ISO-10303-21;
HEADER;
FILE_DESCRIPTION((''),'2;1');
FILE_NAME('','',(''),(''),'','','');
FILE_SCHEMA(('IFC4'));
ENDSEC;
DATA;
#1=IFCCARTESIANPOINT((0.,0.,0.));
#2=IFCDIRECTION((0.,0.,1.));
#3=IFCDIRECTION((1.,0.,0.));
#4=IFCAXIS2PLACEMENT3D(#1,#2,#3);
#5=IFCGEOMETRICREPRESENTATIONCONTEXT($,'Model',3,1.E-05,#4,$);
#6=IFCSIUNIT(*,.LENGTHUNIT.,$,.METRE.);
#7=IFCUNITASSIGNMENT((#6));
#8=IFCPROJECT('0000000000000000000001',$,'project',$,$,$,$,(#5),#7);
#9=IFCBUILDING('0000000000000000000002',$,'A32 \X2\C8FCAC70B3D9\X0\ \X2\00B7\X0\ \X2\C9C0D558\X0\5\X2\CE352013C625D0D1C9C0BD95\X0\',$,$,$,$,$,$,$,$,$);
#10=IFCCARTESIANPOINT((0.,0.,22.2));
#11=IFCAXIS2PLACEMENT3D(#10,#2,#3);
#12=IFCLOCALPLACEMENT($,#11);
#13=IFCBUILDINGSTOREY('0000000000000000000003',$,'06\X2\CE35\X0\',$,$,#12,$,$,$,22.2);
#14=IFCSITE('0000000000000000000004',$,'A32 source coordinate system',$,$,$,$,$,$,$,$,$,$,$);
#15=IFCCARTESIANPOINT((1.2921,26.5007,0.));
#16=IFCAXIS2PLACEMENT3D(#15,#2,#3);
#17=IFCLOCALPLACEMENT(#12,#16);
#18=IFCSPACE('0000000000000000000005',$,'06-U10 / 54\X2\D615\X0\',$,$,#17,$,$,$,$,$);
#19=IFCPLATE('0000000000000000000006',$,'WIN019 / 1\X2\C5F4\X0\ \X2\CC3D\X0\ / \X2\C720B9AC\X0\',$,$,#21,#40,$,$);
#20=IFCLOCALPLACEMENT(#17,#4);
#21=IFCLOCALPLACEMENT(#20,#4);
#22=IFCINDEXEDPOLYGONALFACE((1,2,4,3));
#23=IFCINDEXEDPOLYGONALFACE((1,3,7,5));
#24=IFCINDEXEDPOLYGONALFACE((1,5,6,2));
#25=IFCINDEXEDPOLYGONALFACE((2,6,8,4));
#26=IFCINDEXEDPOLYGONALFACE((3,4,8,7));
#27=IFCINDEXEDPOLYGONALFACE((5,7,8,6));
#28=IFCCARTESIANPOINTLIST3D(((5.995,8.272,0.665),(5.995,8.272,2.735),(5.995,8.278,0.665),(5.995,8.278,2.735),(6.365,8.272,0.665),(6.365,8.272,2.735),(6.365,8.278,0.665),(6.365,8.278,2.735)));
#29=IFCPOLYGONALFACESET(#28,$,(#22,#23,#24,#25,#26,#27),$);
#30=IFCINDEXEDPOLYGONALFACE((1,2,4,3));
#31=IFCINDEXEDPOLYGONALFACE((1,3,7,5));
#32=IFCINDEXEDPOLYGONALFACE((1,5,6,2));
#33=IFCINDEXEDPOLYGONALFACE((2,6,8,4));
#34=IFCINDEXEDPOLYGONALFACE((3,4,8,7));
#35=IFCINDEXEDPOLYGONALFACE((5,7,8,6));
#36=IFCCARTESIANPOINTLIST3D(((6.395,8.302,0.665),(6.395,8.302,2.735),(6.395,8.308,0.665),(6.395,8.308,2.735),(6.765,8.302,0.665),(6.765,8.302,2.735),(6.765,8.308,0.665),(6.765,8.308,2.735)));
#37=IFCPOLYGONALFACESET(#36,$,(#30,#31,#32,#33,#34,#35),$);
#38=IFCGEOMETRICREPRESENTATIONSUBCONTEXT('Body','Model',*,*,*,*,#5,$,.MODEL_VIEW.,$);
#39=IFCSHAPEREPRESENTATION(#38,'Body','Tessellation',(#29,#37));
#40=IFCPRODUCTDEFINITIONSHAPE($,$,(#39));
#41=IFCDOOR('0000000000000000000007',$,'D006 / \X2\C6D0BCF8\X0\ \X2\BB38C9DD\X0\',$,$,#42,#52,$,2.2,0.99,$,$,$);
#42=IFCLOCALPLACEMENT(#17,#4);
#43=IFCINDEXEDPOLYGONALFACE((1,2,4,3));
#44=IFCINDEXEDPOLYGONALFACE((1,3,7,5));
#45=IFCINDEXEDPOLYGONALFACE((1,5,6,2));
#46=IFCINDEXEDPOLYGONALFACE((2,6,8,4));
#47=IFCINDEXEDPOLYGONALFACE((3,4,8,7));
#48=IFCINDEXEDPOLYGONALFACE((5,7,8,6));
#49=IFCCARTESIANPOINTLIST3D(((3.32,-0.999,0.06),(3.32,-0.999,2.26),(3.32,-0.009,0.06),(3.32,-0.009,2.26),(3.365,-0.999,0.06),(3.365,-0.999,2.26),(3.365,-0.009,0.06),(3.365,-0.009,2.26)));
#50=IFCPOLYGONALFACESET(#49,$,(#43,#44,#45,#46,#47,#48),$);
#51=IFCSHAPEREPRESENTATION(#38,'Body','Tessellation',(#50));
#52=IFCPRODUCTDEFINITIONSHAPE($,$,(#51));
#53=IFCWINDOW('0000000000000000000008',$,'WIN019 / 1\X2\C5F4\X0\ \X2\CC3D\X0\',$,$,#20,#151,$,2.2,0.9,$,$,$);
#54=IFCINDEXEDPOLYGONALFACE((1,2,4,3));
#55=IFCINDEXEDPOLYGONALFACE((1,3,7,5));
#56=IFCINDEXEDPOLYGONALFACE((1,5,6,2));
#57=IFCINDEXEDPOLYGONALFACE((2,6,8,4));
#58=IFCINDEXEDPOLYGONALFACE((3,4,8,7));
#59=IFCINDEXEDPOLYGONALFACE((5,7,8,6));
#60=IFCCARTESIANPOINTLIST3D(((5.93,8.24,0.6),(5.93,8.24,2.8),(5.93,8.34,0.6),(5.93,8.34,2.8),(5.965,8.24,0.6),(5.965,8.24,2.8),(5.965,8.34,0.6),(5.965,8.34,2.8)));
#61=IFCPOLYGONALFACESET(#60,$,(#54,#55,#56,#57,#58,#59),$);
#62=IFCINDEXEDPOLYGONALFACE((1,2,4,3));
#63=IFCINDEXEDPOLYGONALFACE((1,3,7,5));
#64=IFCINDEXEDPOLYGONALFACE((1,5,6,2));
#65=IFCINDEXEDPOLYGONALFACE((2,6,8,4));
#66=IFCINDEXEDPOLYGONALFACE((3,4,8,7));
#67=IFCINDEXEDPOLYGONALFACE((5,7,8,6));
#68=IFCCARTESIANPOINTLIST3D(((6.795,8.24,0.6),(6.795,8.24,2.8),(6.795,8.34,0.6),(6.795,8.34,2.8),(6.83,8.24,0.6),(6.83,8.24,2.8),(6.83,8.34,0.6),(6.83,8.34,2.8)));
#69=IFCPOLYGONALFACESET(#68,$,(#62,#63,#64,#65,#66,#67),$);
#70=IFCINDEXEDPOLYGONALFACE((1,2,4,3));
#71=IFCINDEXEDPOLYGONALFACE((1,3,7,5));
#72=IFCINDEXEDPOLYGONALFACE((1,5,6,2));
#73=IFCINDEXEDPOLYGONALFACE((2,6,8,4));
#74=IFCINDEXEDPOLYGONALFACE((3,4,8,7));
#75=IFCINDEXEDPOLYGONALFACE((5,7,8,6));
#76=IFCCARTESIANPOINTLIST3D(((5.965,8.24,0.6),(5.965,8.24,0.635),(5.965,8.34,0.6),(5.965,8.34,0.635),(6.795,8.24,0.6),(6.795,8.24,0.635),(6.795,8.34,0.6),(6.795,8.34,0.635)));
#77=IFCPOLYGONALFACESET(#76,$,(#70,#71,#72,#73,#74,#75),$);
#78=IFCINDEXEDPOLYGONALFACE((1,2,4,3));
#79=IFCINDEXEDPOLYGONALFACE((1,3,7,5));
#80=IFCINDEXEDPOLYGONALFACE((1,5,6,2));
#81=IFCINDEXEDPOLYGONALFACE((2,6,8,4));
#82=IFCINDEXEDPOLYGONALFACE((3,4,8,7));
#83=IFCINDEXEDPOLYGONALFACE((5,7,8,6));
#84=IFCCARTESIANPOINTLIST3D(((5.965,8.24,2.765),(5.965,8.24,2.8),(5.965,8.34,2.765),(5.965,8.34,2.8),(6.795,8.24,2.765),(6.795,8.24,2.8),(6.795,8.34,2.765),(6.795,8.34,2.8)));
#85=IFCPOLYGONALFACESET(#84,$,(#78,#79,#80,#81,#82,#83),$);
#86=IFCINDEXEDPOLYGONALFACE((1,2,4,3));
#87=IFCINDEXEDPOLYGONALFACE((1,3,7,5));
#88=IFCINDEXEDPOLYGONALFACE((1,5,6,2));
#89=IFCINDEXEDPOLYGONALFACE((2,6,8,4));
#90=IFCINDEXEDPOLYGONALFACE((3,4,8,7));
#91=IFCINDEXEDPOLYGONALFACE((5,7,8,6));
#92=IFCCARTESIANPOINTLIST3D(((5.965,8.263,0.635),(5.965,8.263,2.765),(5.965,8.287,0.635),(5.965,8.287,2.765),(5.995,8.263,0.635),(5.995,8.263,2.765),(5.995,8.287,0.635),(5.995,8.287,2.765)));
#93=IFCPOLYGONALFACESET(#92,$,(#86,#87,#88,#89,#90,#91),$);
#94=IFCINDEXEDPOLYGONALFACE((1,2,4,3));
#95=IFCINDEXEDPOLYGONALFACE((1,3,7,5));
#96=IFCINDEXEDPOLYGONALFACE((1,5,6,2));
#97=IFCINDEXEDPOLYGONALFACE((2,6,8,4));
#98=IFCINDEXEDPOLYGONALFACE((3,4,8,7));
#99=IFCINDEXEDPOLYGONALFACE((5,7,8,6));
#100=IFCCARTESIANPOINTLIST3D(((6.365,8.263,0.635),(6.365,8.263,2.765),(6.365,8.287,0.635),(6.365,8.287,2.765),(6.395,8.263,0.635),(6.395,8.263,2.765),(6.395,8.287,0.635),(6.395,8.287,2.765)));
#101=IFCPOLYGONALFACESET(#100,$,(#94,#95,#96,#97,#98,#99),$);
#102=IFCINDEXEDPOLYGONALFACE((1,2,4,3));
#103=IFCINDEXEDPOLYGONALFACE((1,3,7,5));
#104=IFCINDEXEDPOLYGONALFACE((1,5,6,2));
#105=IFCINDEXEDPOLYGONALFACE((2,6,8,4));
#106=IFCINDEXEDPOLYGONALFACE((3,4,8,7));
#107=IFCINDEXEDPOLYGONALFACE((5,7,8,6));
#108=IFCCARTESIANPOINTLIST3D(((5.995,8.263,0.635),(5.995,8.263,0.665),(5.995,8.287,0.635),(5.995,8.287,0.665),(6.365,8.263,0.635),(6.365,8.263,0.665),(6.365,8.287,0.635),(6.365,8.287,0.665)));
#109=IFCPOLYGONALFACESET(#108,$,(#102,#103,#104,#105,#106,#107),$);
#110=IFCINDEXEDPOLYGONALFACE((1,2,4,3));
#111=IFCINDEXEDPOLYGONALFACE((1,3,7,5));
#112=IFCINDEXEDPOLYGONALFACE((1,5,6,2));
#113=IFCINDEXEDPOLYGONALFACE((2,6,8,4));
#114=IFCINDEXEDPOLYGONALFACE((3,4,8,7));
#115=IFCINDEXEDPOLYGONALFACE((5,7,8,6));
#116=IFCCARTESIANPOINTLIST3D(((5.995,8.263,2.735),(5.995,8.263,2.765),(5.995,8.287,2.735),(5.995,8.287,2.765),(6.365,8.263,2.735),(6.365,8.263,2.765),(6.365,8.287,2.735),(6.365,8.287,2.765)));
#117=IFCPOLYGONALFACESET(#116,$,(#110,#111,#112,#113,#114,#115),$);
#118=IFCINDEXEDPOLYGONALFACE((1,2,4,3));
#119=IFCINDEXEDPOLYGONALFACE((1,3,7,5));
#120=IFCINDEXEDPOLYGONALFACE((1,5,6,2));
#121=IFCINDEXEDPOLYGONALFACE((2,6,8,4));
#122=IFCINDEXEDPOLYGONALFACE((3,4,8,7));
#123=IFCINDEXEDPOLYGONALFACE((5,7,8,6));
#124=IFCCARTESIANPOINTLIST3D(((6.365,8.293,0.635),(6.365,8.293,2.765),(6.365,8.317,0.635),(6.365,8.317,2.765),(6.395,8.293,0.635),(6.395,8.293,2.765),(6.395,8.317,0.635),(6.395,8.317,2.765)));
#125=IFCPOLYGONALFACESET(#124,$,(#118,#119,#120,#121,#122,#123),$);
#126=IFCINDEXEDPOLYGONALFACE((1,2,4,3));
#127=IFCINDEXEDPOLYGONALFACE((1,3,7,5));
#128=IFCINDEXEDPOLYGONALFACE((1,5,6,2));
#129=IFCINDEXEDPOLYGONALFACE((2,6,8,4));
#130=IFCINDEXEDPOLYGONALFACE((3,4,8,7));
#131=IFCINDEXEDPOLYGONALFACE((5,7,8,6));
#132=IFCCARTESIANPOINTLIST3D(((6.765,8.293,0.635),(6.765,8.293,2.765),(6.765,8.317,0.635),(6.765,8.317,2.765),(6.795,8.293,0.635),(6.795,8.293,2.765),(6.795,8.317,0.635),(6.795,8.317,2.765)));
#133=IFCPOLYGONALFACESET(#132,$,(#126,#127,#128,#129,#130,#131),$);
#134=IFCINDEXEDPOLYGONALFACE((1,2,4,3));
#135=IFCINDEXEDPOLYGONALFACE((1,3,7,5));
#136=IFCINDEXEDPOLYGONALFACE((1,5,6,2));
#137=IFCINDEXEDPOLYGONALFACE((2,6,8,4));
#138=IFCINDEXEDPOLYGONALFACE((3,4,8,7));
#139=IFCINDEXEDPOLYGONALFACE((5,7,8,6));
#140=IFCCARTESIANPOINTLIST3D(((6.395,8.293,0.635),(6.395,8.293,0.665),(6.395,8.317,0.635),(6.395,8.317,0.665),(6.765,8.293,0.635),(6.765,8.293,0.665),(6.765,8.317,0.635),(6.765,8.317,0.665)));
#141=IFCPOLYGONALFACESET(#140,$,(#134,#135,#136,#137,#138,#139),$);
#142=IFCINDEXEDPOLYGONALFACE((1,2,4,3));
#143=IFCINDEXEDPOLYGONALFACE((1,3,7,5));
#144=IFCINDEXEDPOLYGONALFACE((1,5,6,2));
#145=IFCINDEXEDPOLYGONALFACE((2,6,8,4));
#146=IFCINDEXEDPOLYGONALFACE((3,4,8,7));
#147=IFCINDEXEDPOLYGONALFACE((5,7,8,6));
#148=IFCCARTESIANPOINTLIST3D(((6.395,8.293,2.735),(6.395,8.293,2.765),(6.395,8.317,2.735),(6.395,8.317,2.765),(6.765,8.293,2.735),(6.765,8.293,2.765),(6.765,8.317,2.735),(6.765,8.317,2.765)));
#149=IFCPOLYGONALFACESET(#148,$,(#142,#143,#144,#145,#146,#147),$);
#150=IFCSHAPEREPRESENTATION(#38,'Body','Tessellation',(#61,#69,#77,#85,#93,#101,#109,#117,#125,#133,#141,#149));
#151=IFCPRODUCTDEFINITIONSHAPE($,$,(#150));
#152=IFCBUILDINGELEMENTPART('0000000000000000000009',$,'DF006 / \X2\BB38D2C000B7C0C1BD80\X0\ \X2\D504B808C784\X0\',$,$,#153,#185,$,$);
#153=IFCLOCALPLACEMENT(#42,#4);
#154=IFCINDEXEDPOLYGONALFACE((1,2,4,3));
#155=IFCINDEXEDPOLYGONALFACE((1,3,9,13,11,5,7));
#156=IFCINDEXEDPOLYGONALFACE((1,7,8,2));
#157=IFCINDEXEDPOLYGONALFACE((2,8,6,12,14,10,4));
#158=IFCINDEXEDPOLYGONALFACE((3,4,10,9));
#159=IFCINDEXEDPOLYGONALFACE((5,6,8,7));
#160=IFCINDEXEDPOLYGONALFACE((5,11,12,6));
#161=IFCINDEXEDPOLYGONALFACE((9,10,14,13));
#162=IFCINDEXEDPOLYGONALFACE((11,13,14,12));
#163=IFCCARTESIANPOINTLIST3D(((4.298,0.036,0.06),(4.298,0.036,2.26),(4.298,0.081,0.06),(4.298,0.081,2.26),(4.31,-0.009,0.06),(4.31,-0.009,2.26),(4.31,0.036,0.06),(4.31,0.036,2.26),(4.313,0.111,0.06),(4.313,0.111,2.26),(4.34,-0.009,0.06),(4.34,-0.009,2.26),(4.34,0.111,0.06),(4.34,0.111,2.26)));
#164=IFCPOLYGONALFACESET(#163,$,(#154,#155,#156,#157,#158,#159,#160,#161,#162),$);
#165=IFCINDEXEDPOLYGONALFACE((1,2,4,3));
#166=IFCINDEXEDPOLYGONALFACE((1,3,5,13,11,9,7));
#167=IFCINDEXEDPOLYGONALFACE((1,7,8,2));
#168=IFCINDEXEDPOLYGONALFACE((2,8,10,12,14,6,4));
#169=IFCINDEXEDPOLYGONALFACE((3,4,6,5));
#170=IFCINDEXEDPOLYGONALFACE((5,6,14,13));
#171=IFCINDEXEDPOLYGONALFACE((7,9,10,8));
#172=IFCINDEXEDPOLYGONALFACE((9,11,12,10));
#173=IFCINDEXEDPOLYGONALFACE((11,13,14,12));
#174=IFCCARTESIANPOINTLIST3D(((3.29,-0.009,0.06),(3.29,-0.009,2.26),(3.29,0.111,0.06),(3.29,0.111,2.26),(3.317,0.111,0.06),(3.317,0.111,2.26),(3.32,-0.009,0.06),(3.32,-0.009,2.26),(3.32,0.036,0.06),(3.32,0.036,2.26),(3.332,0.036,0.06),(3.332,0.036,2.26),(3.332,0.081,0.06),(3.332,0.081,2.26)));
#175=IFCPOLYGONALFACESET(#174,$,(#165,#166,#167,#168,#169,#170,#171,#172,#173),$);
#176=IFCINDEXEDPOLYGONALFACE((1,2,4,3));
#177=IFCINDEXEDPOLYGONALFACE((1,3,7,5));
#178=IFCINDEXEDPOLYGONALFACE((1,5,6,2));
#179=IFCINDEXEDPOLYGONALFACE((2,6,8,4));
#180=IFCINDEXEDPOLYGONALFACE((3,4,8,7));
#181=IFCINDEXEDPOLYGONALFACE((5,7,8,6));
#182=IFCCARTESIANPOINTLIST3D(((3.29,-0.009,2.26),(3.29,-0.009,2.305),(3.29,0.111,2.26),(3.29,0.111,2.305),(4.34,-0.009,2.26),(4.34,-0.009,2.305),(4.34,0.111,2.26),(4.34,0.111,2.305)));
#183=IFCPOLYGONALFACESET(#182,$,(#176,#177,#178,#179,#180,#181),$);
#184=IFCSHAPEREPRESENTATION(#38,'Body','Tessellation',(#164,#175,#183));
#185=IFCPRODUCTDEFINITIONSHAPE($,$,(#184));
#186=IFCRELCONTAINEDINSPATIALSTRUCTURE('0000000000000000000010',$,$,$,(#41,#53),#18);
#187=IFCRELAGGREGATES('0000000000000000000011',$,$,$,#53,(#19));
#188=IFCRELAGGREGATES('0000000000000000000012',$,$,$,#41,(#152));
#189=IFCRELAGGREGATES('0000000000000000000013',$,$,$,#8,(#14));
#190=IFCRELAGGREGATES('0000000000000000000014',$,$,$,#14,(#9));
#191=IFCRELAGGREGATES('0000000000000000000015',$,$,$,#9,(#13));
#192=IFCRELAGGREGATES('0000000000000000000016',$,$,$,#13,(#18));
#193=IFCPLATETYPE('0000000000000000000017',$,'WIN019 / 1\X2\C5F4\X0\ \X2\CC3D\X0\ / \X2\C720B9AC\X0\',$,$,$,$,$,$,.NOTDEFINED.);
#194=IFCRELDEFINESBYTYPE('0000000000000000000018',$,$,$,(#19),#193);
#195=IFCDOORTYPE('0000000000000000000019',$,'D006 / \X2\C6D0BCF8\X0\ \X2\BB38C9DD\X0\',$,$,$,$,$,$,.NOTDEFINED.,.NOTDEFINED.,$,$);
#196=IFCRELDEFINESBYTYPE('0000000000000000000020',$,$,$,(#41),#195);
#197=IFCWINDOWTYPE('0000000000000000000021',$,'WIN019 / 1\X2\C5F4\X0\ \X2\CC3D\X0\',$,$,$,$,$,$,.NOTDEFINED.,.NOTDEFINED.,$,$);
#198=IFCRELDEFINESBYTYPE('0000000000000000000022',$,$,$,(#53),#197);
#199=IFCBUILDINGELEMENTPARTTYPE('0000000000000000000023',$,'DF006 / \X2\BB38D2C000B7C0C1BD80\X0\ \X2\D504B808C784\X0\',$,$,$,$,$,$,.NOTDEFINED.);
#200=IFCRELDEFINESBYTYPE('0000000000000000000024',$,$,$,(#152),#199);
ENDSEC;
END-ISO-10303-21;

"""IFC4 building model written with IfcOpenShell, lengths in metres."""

from ifc_helpers import new_model, si_unit, frame, origin, origin_with_axes, place, context, subcontext, project, spatial, polyline, outline, extrude, source, transform, mapped, type_object, type_shapes, element, aggregate, save


model = new_model("IFC4")

# Units and contexts
model_context = context("Model", 3, precision=1e-05, world=origin_with_axes())
body_context = subcontext(model_context, "Body", "Model", "MODEL_VIEW")
ifc_project = project(units=[si_unit("LENGTHUNIT", "METRE")], contexts=[model_context])

# Plate
storey_placement = place(None, frame((0.0, 0.0, 22.2), z_axis=(0.0, 0.0, 1.0), x_axis=(1.0, 0.0, 0.0)))
space_placement = place(storey_placement, frame((1.2921, 26.5007, 0.0), z_axis=(0.0, 0.0, 1.0), x_axis=(1.0, 0.0, 0.0)))
plate_type_1 = type_object("IfcPlateType", Name="WIN019 / 1열 창 / 유리", PredefinedType="NOTDEFINED")
shared_shape_1 = source(origin(), body_context, "Body", "SweptSolid", [
    extrude(outline(polyline([(5.995, 8.272), (5.995, 8.278), (6.365, 8.278), (6.365, 8.272), (5.995, 8.272)])), frame((0.0, 0.0, 0.665)), (0.0, 0.0, 1.0), 2.07),
    extrude(outline(polyline([(6.395, 8.302), (6.395, 8.308), (6.765, 8.308), (6.765, 8.302), (6.395, 8.302)])), frame((0.0, 0.0, 0.665)), (0.0, 0.0, 1.0), 2.07),
])
type_shapes(plate_type_1, [shared_shape_1])
window_1_placement = place(space_placement, origin_with_axes())
plate_1_placement = place(window_1_placement, origin_with_axes())
plate_1 = element("IfcPlate", 1, at=plate_1_placement, type_object=plate_type_1, Name="WIN019 / 1열 창 / 유리", context=body_context, shape_type="MappedRepresentation", body=[
    mapped(shared_shape_1, transform((0.0, 0.0, 0.0), scale=1.0)),
])

# Site, building, storey, space
site = spatial("IfcSite", under=ifc_project, Name="A32 source coordinate system")
building = spatial("IfcBuilding", under=site, Name="A32 주거동 · 지하5층–옥탑지붕")
storey = spatial("IfcBuildingStorey", under=building, at=storey_placement, Name="06층", Elevation=22.2)
space = spatial("IfcSpace", under=storey, at=space_placement, Name="06-U10 / 54형")

# Door
door_type_1 = type_object("IfcDoorType", Name="D006 / 원본 문짝", OperationType="NOTDEFINED", PredefinedType="NOTDEFINED")
shared_shape_2 = source(origin(), body_context, "Body", "SweptSolid", [
    extrude(outline(polyline([(3.365, -0.999), (3.32, -0.999), (3.32, -0.009), (3.365, -0.009), (3.365, -0.999)])), frame((0.0, 0.0, 0.06)), (0.0, 0.0, 1.0), 2.2),
])
type_shapes(door_type_1, [shared_shape_2])
door_1_placement = place(space_placement, origin_with_axes())
door_1 = element("IfcDoor", 2, at=door_1_placement, inside=space, type_object=door_type_1, Name="D006 / 원본 문짝", OverallHeight=2.2, OverallWidth=0.99, context=body_context, shape_type="MappedRepresentation", body=[
    mapped(shared_shape_2, transform((0.0, 0.0, 0.0), scale=1.0)),
])

# Window
window_type_1 = type_object("IfcWindowType", Name="WIN019 / 1열 창", PartitioningType="NOTDEFINED", PredefinedType="NOTDEFINED")
shared_shape_3 = source(origin(), body_context, "Body", "SweptSolid", [
    extrude(outline(polyline([(5.93, 8.24), (5.93, 8.34), (5.965, 8.34), (5.965, 8.24), (5.93, 8.24)])), frame((0.0, 0.0, 0.6)), (0.0, 0.0, 1.0), 2.2),
    extrude(outline(polyline([(6.795, 8.24), (6.795, 8.34), (6.83, 8.34), (6.83, 8.24), (6.795, 8.24)])), frame((0.0, 0.0, 0.6)), (0.0, 0.0, 1.0), 2.2),
    extrude(outline(polyline([(5.965, 8.24), (5.965, 8.34), (6.795, 8.34), (6.795, 8.24), (5.965, 8.24)])), frame((0.0, 0.0, 0.6)), (0.0, 0.0, 1.0), 0.035),
    extrude(outline(polyline([(5.965, 8.24), (5.965, 8.34), (6.795, 8.34), (6.795, 8.24), (5.965, 8.24)])), frame((0.0, 0.0, 2.765)), (0.0, 0.0, 1.0), 0.035),
    extrude(outline(polyline([(5.965, 8.263), (5.965, 8.287), (5.995, 8.287), (5.995, 8.263), (5.965, 8.263)])), frame((0.0, 0.0, 0.635)), (0.0, 0.0, 1.0), 2.13),
    extrude(outline(polyline([(6.365, 8.263), (6.365, 8.287), (6.395, 8.287), (6.395, 8.263), (6.365, 8.263)])), frame((0.0, 0.0, 0.635)), (0.0, 0.0, 1.0), 2.13),
    extrude(outline(polyline([(5.995, 8.263), (5.995, 8.287), (6.365, 8.287), (6.365, 8.263), (5.995, 8.263)])), frame((0.0, 0.0, 0.635)), (0.0, 0.0, 1.0), 0.03),
    extrude(outline(polyline([(5.995, 8.263), (5.995, 8.287), (6.365, 8.287), (6.365, 8.263), (5.995, 8.263)])), frame((0.0, 0.0, 2.735)), (0.0, 0.0, 1.0), 0.03),
    extrude(outline(polyline([(6.365, 8.293), (6.365, 8.317), (6.395, 8.317), (6.395, 8.293), (6.365, 8.293)])), frame((0.0, 0.0, 0.635)), (0.0, 0.0, 1.0), 2.13),
    extrude(outline(polyline([(6.765, 8.293), (6.765, 8.317), (6.795, 8.317), (6.795, 8.293), (6.765, 8.293)])), frame((0.0, 0.0, 0.635)), (0.0, 0.0, 1.0), 2.13),
    extrude(outline(polyline([(6.395, 8.293), (6.395, 8.317), (6.765, 8.317), (6.765, 8.293), (6.395, 8.293)])), frame((0.0, 0.0, 0.635)), (0.0, 0.0, 1.0), 0.03),
    extrude(outline(polyline([(6.395, 8.293), (6.395, 8.317), (6.765, 8.317), (6.765, 8.293), (6.395, 8.293)])), frame((0.0, 0.0, 2.735)), (0.0, 0.0, 1.0), 0.03),
])
type_shapes(window_type_1, [shared_shape_3])
window_1 = element("IfcWindow", 3, at=window_1_placement, inside=space, type_object=window_type_1, Name="WIN019 / 1열 창", OverallHeight=2.2, OverallWidth=0.9, context=body_context, shape_type="MappedRepresentation", body=[
    mapped(shared_shape_3, transform((0.0, 0.0, 0.0), scale=1.0)),
])
aggregate(window_1, [plate_1])

# Building element part
building_element_part_type_1 = type_object("IfcBuildingElementPartType", Name="DF006 / 문틀·상부 프레임", PredefinedType="NOTDEFINED")
shared_shape_4 = source(origin(), body_context, "Body", "SweptSolid", [
    extrude(outline(polyline([(4.31, -0.009), (4.31, 0.036), (4.298, 0.036), (4.298, 0.081), (4.313, 0.111), (4.34, 0.111), (4.34, -0.009), (4.31, -0.009)])), frame((0.0, 0.0, 0.06)), (0.0, 0.0, 1.0), 2.2),
    extrude(outline(polyline([(3.29, 0.111), (3.317, 0.111), (3.332, 0.081), (3.332, 0.036), (3.32, 0.036), (3.32, -0.009), (3.29, -0.009), (3.29, 0.111)])), frame((0.0, 0.0, 0.06)), (0.0, 0.0, 1.0), 2.2),
    extrude(outline(polyline([(3.29, -0.009), (3.29, 0.111), (4.34, 0.111), (4.34, -0.009), (3.29, -0.009)])), frame((0.0, 0.0, 2.26)), (0.0, 0.0, 1.0), 0.045),
])
type_shapes(building_element_part_type_1, [shared_shape_4])
building_element_part_1_placement = place(door_1_placement, origin_with_axes())
building_element_part_1 = element("IfcBuildingElementPart", 4, at=building_element_part_1_placement, type_object=building_element_part_type_1, Name="DF006 / 문틀·상부 프레임", context=body_context, shape_type="MappedRepresentation", body=[
    mapped(shared_shape_4, transform((0.0, 0.0, 0.0), scale=1.0)),
])
aggregate(door_1, [building_element_part_1])

save(model, "model.ifc")
